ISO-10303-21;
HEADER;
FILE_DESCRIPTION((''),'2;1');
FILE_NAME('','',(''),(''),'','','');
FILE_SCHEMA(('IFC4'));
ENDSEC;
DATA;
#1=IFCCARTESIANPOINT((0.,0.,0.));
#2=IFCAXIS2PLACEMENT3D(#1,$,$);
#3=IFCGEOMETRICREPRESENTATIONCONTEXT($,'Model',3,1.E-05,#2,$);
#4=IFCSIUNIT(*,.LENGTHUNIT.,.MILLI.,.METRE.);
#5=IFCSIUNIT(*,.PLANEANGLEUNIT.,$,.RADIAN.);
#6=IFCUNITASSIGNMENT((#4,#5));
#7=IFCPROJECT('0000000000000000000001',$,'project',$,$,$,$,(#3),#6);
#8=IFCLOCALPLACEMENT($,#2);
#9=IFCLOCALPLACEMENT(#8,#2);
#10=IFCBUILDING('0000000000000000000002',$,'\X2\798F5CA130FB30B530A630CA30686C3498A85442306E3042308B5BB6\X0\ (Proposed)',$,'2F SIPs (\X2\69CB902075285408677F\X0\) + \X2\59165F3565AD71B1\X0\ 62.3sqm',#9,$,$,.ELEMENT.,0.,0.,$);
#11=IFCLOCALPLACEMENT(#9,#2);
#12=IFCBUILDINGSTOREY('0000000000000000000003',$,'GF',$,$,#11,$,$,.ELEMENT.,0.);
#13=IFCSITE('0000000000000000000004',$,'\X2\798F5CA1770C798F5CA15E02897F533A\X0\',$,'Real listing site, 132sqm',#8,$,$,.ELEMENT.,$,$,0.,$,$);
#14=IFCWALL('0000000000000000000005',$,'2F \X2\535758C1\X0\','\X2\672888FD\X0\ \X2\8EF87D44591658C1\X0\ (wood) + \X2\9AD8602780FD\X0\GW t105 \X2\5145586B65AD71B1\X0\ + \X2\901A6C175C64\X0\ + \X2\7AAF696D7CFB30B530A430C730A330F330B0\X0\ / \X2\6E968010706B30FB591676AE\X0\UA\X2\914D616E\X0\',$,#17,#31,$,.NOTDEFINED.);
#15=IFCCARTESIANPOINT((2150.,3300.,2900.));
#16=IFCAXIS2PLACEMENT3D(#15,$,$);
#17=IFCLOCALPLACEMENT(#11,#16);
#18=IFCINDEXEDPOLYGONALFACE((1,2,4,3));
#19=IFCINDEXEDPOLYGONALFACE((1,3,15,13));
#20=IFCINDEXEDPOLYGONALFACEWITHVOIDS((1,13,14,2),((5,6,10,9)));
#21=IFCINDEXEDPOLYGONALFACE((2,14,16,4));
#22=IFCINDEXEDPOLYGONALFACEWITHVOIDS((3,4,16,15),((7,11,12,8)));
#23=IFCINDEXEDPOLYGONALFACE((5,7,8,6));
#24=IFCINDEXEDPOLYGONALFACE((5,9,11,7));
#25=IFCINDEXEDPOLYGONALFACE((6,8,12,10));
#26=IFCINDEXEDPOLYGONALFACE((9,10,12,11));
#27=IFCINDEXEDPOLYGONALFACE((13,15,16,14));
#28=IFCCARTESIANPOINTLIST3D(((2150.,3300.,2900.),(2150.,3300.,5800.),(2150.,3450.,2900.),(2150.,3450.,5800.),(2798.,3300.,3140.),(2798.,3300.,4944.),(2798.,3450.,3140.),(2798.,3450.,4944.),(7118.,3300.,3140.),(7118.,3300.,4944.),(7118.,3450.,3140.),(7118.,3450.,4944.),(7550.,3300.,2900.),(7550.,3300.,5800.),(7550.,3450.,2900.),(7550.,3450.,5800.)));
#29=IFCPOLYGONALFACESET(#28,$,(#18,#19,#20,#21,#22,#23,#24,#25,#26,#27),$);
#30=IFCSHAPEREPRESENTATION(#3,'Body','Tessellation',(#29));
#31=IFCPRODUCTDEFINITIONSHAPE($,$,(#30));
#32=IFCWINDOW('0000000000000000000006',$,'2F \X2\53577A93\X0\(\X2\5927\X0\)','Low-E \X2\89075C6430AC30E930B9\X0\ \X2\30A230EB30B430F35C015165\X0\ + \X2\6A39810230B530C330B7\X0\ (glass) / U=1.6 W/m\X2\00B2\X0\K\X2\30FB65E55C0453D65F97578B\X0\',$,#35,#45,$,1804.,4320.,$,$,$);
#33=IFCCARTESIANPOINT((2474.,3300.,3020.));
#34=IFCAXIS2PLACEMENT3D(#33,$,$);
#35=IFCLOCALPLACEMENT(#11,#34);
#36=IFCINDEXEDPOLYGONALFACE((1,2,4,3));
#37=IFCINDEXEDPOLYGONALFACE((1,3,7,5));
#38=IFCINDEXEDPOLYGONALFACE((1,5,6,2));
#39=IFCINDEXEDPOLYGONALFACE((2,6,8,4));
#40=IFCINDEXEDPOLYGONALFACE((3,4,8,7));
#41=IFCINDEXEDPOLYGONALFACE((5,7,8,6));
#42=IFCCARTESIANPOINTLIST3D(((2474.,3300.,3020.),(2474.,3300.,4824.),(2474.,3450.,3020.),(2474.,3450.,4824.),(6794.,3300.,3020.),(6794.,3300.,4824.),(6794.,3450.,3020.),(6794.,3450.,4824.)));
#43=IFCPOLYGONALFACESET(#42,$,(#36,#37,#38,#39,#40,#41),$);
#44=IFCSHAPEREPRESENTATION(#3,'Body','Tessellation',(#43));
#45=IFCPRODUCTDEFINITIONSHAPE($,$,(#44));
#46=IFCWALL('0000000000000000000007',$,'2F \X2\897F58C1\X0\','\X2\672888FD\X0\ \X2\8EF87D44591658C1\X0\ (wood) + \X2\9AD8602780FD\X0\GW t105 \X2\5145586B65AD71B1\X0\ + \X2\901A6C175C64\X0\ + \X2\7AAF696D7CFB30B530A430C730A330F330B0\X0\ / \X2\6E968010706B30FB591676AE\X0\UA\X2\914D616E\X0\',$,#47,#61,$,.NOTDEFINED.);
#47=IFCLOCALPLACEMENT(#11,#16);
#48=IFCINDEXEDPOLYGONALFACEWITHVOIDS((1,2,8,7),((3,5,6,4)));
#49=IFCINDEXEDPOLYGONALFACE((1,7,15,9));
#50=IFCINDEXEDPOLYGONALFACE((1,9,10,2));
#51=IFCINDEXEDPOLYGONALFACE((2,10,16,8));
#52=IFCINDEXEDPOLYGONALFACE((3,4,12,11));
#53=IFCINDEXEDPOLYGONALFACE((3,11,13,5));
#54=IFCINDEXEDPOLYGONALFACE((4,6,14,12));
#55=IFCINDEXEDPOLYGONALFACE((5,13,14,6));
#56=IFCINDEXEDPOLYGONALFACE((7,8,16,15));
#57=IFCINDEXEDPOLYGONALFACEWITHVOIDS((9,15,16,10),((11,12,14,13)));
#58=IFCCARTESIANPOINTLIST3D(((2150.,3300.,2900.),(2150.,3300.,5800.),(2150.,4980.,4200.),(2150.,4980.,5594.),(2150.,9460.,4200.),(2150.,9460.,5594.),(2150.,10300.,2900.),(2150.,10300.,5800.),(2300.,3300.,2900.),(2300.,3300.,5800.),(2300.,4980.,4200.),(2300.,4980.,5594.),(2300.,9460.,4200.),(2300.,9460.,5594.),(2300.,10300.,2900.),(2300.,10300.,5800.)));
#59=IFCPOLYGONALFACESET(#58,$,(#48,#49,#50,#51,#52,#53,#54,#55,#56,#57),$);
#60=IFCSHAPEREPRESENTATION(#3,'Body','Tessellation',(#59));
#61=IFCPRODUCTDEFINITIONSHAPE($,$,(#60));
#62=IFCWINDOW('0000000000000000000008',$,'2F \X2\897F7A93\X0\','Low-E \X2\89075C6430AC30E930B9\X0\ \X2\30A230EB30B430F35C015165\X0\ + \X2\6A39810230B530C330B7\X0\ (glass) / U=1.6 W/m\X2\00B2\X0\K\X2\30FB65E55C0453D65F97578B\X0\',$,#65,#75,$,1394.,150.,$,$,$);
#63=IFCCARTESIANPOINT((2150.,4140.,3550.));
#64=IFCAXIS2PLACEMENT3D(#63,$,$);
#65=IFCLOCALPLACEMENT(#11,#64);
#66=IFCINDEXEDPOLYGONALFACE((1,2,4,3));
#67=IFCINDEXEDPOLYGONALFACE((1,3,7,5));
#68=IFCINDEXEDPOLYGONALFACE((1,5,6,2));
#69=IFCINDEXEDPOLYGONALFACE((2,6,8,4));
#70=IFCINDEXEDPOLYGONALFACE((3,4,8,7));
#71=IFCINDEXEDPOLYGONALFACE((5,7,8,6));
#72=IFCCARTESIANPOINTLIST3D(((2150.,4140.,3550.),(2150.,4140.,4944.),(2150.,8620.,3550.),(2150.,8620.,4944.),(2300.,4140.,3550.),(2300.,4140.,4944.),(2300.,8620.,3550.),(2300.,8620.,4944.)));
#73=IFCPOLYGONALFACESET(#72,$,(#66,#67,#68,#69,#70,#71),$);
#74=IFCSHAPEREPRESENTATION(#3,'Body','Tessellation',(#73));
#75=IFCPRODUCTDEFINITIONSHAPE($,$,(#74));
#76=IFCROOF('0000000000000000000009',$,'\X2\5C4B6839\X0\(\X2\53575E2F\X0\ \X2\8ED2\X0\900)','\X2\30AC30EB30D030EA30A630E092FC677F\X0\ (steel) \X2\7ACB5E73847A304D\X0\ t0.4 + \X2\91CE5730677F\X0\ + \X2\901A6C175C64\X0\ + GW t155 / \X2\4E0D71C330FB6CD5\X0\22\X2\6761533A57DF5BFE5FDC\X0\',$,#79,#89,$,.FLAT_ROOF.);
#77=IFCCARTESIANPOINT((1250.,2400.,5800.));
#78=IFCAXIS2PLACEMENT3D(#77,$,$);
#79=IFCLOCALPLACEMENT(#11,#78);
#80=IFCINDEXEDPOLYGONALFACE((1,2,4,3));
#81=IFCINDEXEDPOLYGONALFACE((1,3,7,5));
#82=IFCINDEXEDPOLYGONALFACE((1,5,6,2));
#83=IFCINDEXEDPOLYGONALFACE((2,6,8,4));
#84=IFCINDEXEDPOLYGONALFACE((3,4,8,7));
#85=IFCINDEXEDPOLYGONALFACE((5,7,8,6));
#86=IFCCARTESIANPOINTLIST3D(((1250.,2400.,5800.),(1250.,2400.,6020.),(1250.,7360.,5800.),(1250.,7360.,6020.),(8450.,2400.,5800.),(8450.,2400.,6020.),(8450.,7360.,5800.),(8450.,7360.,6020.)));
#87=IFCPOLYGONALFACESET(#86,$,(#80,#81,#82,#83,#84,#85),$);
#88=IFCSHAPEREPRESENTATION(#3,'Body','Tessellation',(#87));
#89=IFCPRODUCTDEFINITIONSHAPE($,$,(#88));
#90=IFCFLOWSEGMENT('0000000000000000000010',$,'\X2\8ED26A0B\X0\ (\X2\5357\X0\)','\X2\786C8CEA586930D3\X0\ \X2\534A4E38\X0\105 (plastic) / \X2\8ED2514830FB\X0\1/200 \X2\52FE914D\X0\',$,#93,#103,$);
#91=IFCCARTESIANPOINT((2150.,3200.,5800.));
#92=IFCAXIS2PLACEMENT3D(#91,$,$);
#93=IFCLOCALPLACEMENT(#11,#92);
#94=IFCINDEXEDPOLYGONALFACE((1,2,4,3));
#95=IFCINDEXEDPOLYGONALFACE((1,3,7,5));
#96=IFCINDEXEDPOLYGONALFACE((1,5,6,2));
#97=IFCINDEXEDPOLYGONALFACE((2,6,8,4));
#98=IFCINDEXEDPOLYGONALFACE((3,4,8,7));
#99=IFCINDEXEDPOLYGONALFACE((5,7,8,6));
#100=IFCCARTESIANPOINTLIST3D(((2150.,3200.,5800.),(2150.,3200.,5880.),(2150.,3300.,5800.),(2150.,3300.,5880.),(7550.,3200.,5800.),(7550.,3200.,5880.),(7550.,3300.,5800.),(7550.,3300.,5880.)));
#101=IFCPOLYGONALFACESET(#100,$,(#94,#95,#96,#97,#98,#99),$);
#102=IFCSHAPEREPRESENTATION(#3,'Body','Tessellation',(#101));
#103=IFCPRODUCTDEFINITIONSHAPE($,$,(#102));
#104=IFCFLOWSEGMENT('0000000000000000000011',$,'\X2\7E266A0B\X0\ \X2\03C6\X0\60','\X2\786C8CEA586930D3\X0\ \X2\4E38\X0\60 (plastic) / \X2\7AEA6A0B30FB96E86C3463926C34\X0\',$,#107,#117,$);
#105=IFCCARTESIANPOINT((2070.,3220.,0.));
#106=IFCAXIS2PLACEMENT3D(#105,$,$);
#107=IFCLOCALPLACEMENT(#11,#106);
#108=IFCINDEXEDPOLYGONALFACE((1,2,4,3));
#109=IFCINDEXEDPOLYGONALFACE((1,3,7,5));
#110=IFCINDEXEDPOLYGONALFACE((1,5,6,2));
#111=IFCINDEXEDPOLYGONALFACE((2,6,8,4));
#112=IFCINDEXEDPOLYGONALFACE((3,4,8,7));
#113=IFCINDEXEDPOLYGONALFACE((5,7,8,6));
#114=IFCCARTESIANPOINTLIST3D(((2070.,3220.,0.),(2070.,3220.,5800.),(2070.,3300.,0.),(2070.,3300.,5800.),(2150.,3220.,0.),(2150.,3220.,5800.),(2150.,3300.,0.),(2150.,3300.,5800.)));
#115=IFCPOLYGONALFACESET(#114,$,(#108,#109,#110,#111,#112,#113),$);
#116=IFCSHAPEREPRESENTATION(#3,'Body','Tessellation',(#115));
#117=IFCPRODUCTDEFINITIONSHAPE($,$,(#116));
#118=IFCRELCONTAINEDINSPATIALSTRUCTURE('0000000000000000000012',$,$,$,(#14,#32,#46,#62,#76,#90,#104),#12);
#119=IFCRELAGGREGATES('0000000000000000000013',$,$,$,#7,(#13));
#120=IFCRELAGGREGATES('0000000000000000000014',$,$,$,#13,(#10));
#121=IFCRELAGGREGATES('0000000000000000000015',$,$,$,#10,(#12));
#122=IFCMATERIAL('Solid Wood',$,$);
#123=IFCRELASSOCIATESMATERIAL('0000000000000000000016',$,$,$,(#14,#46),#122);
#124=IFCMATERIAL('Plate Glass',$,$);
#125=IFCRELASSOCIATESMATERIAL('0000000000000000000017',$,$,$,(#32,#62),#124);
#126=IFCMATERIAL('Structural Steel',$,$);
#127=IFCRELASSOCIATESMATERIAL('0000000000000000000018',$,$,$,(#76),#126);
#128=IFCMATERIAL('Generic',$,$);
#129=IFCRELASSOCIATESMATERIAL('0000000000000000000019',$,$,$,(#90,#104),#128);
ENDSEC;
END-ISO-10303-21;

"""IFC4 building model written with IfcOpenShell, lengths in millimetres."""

from ifc_helpers import new_model, si_unit, frame, frame_2d, origin, place, context, project, spatial, rectangle, extrude, material, element, fill, save


model = new_model("IFC4")

# Units and contexts
model_context = context("Model", 3, precision=1e-05, world=origin())
ifc_project = project(units=[si_unit("LENGTHUNIT", "METRE", prefix="MILLI"), si_unit("PLANEANGLEUNIT", "RADIAN")], contexts=[model_context])

# Site, building, storey
site_placement = place(None, origin())
site = spatial("IfcSite", under=ifc_project, at=site_placement, Name="福岡県福岡市西区", ObjectType="Real listing site, 132sqm", CompositionType="ELEMENT", RefElevation=0.0)
building_placement = place(site_placement, origin())
building = spatial("IfcBuilding", under=site, at=building_placement, Name="福岡・サウナと水風呂のある家 (Proposed)", ObjectType="2F SIPs (構造用合板) + 外張断熱 62.3sqm", CompositionType="ELEMENT", ElevationOfRefHeight=0.0, ElevationOfTerrain=0.0)
storey_placement = place(building_placement, origin())
storey = spatial("IfcBuildingStorey", under=building, at=storey_placement, Name="GF", CompositionType="ELEMENT", Elevation=0.0)

# Shared definitions
ifc_material_1 = material(Name="Solid Wood")

# Shared definitions
ifc_material_2 = material(Name="Plate Glass")

# Walls, openings, windows
wall_1_placement = place(storey_placement, frame((2150.0, 3300.0, 2900.0)))
wall_1 = element("IfcWall", 1, at=wall_1_placement, inside=storey, material=ifc_material_1, Name="2F 南壁", Description="木製 軸組外壁 (wood) + 高性能GW t105 充填断熱 + 通気層 + 窯業系サイディング / 準耐火・外皮UA配慮", PredefinedType="NOTDEFINED", context=model_context, shape_type="SweptSolid", body=[
    extrude(rectangle(XDim=5400.0, YDim=150.0, at=frame_2d((2700.0, 75.0))), frame((2150.0, 3300.0, 2900.0)), (0.0, 0.0, 1.0), 2900.0),
])
opening_1_placement = place(storey_placement, frame((2474.0, 3300.0, 3020.0)))
opening_1 = element("IfcOpeningElement", 2, at=opening_1_placement, cuts=wall_1, PredefinedType="NOTDEFINED", context=model_context, shape_type="SweptSolid", body=[
    extrude(rectangle(XDim=4320.0, YDim=150.0, at=frame_2d((2160.0, 75.0))), frame((2474.0, 3300.0, 3020.0)), (0.0, 0.0, 1.0), 1804.0),
])
window_1_placement = place(storey_placement, frame((2474.0, 3300.0, 3020.0)))
window_1 = element("IfcWindow", 3, at=window_1_placement, inside=storey, material=ifc_material_2, Name="2F 南窓(大)", Description="Low-E 複層ガラス アルゴン封入 + 樹脂サッシ (glass) / U=1.6 W/m²K・日射取得型", OverallHeight=1804.0, OverallWidth=4320.0, context=model_context, shape_type="SweptSolid", body=[
    extrude(rectangle(XDim=4320.0, YDim=150.0, at=frame_2d((2160.0, 75.0))), frame((2474.0, 3300.0, 3020.0)), (0.0, 0.0, 1.0), 1804.0),
])
fill(opening_1, window_1)
wall_2_placement = place(storey_placement, frame((2150.0, 3300.0, 2900.0)))
wall_2 = element("IfcWall", 4, at=wall_2_placement, inside=storey, material=ifc_material_1, Name="2F 西壁", Description="木製 軸組外壁 (wood) + 高性能GW t105 充填断熱 + 通気層 + 窯業系サイディング / 準耐火・外皮UA配慮", PredefinedType="NOTDEFINED", context=model_context, shape_type="SweptSolid", body=[
    extrude(rectangle(XDim=150.0, YDim=7000.0, at=frame_2d((75.0, 3500.0))), frame((2150.0, 3300.0, 2900.0)), (0.0, 0.0, 1.0), 2900.0),
])
opening_2_placement = place(storey_placement, frame((2150.0, 4140.0, 3550.0)))
opening_2 = element("IfcOpeningElement", 5, at=opening_2_placement, cuts=wall_2, PredefinedType="NOTDEFINED", context=model_context, shape_type="SweptSolid", body=[
    extrude(rectangle(XDim=150.0, YDim=4480.0, at=frame_2d((75.0, 2240.0))), frame((2150.0, 4140.0, 3550.0)), (0.0, 0.0, 1.0), 1394.0),
])
window_2_placement = place(storey_placement, frame((2150.0, 4140.0, 3550.0)))
window_2 = element("IfcWindow", 6, at=window_2_placement, inside=storey, material=ifc_material_2, Name="2F 西窓", Description="Low-E 複層ガラス アルゴン封入 + 樹脂サッシ (glass) / U=1.6 W/m²K・日射取得型", OverallHeight=1394.0, OverallWidth=150.0, context=model_context, shape_type="SweptSolid", body=[
    extrude(rectangle(XDim=150.0, YDim=4480.0, at=frame_2d((75.0, 2240.0))), frame((2150.0, 4140.0, 3550.0)), (0.0, 0.0, 1.0), 1394.0),
])
fill(opening_2, window_2)

# Roof
ifc_material_3 = material(Name="Structural Steel")
for number, where, name in (
    (7, (1250.0, 2400.0, 5800.0), "屋根(南帯 軒900)"),
):
    element("IfcRoof", number, at=place(storey_placement, frame(where)), inside=storey, material=ifc_material_3, Name=name, Description="ガルバリウム鋼板 (steel) 立平葺き t0.4 + 野地板 + 通気層 + GW t155 / 不燃・法22条区域対応", PredefinedType="FLAT_ROOF", context=model_context, shape_type="SweptSolid", body=[
        extrude(rectangle(XDim=7200.0, YDim=4960.0, at=frame_2d((3600.0, 2480.0))), frame((1250.0, 2400.0, 5800.0)), (0.0, 0.0, 1.0), 220.0),
    ])

# Flow segments
ifc_material_4 = material(Name="Generic")
flow_segment_1_placement = place(storey_placement, frame((2150.0, 3200.0, 5800.0)))
element("IfcFlowSegment", 8, at=flow_segment_1_placement, inside=storey, material=ifc_material_4, Name="軒樋 (南)", Description="硬質塩ビ 半丸105 (plastic) / 軒先・1/200 勾配", context=model_context, shape_type="SweptSolid", body=[
    extrude(rectangle(XDim=5400.0, YDim=100.0, at=frame_2d((2700.0, 50.0))), frame((2150.0, 3200.0, 5800.0)), (0.0, 0.0, 1.0), 80.0),
])
flow_segment_2_placement = place(storey_placement, frame((2070.0, 3220.0, 0.0)))
element("IfcFlowSegment", 9, at=flow_segment_2_placement, inside=storey, material=ifc_material_4, Name="縦樋 φ60", Description="硬質塩ビ 丸60 (plastic) / 竪樋・雨水排水", context=model_context, shape_type="SweptSolid", body=[
    extrude(rectangle(XDim=80.0, YDim=80.0, at=frame_2d((40.0, 40.0))), frame((2070.0, 3220.0, 0.0)), (0.0, 0.0, 1.0), 5800.0),
])

save(model, "model.ifc")
